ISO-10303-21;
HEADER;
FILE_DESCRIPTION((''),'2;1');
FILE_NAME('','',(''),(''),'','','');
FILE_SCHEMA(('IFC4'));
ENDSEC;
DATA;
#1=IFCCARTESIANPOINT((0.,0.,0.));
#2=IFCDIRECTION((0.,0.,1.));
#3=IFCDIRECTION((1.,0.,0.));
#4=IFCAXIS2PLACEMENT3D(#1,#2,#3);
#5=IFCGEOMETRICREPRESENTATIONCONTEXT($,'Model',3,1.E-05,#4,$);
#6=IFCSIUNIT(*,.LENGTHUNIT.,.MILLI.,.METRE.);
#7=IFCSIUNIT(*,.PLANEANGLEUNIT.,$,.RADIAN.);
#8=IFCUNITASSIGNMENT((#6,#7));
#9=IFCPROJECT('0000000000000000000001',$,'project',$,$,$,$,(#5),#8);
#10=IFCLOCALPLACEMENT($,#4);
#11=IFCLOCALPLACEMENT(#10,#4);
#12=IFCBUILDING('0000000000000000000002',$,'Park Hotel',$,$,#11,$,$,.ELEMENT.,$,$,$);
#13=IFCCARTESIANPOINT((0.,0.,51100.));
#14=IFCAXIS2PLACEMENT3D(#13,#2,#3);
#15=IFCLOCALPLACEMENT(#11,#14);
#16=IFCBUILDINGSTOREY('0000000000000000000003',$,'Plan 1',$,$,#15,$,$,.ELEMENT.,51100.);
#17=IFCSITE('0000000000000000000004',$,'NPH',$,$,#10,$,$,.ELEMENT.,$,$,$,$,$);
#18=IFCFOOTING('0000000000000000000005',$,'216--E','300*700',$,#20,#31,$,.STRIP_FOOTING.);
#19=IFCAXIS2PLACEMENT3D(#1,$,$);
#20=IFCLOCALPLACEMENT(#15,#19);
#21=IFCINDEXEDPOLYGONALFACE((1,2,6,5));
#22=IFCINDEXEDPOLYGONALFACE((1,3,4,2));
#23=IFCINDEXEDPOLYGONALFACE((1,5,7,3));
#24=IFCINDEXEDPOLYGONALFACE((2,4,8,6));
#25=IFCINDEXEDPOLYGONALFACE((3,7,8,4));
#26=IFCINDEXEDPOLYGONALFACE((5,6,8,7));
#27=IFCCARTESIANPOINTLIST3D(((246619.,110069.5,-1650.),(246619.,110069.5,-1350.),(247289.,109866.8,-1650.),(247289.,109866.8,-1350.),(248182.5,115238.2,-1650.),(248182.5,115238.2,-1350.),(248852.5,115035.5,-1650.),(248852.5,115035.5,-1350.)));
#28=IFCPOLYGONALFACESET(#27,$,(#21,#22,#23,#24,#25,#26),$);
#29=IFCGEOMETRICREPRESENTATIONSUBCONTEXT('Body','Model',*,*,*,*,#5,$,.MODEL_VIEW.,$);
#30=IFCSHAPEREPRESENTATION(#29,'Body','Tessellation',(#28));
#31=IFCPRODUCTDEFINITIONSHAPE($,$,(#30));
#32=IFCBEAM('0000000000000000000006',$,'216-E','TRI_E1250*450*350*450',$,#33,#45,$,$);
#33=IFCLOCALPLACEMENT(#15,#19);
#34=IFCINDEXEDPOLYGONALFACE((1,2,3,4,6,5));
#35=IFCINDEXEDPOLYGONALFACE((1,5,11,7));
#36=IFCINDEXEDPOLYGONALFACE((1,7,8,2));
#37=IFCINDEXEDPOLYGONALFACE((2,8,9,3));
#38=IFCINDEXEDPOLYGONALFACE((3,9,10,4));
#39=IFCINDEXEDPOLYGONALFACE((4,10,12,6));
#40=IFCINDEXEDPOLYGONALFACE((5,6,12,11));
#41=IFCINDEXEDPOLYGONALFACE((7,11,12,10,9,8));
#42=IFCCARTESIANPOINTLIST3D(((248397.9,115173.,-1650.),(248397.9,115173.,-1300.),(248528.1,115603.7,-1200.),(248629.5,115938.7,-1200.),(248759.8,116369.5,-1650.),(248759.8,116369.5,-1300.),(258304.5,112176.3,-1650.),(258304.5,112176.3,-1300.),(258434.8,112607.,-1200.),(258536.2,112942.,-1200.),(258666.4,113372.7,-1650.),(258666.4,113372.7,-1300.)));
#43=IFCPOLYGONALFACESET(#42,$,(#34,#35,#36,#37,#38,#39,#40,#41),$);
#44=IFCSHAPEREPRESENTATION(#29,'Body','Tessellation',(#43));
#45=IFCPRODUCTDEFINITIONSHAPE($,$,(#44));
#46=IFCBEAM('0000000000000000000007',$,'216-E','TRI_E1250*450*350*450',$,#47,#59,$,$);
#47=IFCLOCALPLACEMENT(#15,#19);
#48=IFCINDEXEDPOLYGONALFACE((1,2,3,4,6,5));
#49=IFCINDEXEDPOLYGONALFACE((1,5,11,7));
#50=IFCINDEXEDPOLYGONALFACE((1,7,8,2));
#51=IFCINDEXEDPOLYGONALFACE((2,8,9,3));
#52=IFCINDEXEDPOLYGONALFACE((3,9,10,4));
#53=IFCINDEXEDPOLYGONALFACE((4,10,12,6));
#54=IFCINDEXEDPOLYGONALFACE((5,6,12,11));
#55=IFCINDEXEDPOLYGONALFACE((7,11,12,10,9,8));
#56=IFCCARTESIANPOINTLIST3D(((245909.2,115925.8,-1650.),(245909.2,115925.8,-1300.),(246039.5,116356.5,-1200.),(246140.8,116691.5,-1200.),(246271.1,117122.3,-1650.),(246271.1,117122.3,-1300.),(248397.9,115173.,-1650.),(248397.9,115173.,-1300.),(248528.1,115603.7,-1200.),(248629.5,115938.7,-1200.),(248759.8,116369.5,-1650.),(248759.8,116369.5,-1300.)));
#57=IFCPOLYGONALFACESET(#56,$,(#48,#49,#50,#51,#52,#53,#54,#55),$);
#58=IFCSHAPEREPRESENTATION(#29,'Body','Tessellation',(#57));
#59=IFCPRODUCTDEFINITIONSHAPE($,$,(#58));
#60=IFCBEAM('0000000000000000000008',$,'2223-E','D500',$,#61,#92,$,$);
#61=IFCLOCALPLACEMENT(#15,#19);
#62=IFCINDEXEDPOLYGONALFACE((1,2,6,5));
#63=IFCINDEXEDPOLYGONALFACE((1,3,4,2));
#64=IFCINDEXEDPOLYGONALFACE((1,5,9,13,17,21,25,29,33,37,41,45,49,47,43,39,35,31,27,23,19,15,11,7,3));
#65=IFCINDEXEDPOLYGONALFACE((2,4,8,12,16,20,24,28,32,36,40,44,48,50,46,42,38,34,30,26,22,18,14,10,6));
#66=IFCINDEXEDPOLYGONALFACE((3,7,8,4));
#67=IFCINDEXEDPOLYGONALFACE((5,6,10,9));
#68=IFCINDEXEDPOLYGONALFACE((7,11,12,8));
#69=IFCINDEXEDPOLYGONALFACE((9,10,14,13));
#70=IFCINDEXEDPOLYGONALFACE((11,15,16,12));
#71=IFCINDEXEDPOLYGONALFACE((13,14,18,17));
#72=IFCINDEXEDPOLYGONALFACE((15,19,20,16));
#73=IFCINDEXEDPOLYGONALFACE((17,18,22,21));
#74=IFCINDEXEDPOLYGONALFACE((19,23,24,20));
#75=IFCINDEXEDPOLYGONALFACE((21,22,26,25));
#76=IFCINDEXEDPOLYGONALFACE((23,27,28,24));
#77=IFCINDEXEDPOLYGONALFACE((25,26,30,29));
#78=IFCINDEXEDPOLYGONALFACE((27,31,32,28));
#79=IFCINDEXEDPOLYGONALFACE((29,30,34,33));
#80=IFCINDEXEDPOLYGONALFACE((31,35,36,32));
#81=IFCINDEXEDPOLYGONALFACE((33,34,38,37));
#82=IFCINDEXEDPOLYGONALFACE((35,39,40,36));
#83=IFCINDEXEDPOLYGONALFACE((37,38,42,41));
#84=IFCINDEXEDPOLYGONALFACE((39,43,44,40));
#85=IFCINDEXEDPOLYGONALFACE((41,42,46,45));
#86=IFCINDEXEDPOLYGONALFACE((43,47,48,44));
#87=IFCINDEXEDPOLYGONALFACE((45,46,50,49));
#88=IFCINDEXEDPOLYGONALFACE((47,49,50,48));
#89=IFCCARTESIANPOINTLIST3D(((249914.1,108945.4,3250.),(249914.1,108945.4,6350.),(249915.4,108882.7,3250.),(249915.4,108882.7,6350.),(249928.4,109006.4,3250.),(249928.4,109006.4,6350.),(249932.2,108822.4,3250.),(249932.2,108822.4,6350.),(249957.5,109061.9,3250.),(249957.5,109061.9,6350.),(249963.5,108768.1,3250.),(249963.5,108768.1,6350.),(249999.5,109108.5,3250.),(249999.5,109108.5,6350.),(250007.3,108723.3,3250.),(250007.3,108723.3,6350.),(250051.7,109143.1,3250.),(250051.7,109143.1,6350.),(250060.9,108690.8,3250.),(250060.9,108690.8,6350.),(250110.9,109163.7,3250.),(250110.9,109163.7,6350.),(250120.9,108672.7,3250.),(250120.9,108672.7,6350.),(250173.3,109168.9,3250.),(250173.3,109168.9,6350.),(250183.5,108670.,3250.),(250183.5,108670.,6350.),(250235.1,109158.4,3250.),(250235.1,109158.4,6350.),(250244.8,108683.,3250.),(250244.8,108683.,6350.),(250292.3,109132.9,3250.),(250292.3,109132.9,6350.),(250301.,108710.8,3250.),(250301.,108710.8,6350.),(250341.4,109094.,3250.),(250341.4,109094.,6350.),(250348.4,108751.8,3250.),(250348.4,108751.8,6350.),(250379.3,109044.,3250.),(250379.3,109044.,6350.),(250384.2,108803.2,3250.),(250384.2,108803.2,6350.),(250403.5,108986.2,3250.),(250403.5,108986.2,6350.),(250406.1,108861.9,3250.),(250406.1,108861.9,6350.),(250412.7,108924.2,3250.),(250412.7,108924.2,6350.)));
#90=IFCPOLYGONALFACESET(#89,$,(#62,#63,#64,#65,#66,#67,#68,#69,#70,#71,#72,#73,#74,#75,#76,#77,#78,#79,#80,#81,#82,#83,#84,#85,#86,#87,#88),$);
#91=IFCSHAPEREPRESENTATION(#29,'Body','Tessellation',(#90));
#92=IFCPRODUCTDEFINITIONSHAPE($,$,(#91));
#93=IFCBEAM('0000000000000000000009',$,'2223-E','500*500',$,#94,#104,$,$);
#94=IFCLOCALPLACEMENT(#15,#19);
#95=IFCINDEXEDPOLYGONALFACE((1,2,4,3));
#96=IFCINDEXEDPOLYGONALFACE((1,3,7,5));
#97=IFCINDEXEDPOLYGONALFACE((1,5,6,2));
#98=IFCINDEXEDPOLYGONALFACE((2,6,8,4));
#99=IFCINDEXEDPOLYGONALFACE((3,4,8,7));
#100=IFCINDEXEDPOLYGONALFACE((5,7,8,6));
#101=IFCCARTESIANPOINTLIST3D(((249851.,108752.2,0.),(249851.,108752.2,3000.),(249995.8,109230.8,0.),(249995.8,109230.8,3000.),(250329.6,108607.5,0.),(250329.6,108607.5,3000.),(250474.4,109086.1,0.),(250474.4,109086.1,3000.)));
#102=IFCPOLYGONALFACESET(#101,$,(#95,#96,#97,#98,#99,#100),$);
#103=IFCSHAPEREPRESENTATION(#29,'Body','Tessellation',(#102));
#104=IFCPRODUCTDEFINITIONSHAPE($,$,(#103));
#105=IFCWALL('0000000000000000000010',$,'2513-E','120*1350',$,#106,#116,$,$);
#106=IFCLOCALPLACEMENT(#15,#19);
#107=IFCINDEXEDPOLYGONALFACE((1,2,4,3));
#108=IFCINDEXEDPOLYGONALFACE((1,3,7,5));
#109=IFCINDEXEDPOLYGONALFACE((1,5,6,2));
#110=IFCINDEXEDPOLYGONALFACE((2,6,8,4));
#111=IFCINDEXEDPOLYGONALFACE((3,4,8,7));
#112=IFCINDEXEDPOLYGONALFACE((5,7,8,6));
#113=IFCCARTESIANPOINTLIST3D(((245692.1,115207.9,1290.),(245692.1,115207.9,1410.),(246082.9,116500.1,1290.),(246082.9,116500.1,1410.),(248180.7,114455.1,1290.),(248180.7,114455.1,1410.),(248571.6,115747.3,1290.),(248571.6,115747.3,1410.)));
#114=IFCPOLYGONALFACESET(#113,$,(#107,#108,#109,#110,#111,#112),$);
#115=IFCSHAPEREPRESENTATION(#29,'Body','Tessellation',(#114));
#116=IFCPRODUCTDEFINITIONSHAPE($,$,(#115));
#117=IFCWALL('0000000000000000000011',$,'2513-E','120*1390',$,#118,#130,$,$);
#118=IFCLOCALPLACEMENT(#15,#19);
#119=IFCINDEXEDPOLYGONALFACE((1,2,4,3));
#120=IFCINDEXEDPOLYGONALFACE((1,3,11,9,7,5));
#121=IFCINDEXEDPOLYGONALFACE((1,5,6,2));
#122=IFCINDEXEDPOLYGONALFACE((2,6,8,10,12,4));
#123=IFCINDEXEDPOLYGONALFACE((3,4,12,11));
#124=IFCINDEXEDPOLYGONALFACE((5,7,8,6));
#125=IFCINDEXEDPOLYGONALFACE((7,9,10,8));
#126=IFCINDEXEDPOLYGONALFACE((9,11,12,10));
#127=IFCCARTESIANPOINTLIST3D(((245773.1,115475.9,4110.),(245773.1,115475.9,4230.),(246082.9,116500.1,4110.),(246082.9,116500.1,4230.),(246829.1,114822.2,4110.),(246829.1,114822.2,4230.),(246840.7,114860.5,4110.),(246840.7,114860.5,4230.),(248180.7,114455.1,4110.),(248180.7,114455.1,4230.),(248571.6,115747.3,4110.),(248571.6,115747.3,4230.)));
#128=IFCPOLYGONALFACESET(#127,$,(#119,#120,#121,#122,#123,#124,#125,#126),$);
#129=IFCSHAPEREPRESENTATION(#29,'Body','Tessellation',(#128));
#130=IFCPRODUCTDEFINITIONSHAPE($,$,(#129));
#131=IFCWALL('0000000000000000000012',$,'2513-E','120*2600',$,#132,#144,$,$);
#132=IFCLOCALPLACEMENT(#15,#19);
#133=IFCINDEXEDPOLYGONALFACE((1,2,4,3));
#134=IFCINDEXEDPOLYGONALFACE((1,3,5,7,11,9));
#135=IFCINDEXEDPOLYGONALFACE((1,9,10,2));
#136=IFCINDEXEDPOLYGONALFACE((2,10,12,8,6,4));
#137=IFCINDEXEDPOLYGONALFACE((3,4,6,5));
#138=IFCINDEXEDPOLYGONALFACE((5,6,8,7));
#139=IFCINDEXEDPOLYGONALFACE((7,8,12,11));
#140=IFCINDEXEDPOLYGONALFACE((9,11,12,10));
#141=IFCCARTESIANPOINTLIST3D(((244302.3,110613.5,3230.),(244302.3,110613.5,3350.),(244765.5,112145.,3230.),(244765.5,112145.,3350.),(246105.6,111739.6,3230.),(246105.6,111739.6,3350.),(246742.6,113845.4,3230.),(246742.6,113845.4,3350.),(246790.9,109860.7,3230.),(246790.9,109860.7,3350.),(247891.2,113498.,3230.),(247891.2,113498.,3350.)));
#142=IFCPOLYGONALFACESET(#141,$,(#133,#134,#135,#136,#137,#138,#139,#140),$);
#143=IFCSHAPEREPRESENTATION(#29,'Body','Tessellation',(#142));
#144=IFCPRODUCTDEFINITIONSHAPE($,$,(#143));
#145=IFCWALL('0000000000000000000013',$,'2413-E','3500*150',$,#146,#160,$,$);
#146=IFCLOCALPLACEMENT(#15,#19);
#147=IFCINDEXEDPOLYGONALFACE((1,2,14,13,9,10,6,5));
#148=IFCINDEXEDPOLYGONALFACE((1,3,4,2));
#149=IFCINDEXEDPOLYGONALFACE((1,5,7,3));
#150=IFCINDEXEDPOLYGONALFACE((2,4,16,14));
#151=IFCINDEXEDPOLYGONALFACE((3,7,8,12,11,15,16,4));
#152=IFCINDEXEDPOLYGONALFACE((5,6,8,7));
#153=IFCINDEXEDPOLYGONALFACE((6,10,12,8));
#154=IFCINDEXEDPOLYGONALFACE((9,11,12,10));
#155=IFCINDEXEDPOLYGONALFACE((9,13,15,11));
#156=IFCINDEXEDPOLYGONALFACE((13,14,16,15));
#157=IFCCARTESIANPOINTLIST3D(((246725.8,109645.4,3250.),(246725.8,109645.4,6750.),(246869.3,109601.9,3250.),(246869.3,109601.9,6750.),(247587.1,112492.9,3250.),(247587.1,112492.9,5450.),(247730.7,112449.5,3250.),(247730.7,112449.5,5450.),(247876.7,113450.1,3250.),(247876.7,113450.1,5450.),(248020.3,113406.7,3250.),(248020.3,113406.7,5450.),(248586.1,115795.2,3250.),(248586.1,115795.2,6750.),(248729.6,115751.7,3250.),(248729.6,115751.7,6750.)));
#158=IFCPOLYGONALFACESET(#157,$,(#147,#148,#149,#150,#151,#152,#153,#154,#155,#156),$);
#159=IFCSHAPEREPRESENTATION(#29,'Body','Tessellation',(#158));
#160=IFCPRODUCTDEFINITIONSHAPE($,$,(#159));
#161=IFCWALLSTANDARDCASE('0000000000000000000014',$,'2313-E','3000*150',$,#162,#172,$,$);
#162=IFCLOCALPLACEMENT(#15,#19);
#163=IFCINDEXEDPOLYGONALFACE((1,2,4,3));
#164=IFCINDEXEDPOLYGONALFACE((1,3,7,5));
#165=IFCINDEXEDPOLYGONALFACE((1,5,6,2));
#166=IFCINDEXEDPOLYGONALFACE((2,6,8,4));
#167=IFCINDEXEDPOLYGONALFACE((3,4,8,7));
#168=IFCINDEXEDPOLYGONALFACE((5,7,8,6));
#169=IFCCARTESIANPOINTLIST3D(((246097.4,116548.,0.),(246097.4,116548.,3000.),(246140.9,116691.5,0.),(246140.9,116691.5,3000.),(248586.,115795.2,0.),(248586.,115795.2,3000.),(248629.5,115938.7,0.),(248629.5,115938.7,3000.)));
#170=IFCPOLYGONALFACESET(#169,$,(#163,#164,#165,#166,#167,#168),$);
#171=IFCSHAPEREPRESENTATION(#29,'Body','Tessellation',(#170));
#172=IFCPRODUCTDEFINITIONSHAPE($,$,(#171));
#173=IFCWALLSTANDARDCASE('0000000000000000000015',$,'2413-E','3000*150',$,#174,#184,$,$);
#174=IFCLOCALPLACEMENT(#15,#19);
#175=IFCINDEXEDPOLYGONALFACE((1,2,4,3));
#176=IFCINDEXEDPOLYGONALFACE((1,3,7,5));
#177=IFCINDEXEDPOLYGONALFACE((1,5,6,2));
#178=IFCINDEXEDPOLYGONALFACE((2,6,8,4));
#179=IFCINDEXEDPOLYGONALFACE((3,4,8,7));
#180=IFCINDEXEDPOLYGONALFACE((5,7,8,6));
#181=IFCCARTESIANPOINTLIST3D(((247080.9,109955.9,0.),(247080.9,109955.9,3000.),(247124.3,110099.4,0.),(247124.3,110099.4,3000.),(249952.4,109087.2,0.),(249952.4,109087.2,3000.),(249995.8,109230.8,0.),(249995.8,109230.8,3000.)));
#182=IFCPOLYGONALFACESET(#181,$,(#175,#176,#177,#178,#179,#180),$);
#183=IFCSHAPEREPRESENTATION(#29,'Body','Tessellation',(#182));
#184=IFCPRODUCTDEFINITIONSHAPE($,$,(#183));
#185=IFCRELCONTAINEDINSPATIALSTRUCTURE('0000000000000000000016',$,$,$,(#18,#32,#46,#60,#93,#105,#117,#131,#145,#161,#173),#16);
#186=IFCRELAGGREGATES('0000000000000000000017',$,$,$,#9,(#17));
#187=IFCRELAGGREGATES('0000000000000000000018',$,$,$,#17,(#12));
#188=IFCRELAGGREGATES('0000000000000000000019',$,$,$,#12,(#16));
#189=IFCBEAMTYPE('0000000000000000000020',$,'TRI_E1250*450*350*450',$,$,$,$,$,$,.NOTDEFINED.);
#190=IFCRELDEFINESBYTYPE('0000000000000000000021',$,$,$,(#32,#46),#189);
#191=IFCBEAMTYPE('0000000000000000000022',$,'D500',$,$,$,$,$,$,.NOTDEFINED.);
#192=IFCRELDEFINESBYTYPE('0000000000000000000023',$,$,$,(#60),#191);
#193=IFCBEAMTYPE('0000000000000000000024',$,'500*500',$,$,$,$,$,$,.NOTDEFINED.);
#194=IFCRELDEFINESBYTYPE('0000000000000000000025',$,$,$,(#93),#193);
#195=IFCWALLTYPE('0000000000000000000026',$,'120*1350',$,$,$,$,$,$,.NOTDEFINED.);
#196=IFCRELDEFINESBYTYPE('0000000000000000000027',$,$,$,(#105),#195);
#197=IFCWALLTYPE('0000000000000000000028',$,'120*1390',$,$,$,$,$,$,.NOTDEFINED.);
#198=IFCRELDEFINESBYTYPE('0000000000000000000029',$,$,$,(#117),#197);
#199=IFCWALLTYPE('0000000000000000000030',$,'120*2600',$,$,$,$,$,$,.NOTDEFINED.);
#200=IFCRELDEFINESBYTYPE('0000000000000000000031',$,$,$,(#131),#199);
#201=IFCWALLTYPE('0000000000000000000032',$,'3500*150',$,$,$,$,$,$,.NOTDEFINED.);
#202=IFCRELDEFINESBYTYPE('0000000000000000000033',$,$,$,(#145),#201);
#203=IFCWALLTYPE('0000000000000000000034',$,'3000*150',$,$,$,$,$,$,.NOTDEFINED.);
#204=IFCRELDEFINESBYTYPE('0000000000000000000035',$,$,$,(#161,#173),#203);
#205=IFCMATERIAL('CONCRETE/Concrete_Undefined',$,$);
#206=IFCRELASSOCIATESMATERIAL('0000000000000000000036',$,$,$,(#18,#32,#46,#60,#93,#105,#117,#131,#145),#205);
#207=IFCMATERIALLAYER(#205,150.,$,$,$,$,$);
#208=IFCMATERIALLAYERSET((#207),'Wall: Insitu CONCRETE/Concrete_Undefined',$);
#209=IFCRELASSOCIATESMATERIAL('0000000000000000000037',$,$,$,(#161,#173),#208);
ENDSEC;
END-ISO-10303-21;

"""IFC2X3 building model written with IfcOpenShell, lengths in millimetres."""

from ifc_helpers import new_model, si_unit, frame, frame_2d, origin_with_axes, origin_2d_with_axis, place, context, subcontext, project, spatial, polyline, rectangle, circle, outline, extrude, boolean, material, layer, layer_set, layer_usage, type_object, element, save


model = new_model("IFC2X3")

# Units and contexts
model_context = context("Model", 3, precision=1e-05, world=origin_with_axes())
body_context = subcontext(model_context, "Body", "Model", "MODEL_VIEW")
ifc_project = project(units=[si_unit("LENGTHUNIT", "METRE", prefix="MILLI"), si_unit("PLANEANGLEUNIT", "RADIAN")], contexts=[model_context])

# Site, building, storey
site_placement = place(None, origin_with_axes())
site = spatial("IfcSite", under=ifc_project, at=site_placement, Name="NPH", CompositionType="ELEMENT")
building_placement = place(site_placement, origin_with_axes())
building = spatial("IfcBuilding", under=site, at=building_placement, Name="Park Hotel", CompositionType="ELEMENT")
storey_placement = place(building_placement, frame((0.0, 0.0, 51100.0), z_axis=(0.0, 0.0, 1.0), x_axis=(1.0, 0.0, 0.0)))
storey = spatial("IfcBuildingStorey", under=building, at=storey_placement, Name="Plan 1", CompositionType="ELEMENT", Elevation=51100.0)

# Footing
ifc_material_1 = material(Name="CONCRETE/Concrete_Undefined")
footing_placement = place(storey_placement, frame((246954.0, 109968.1, -1500.0), z_axis=(0.0, 0.0, 1.0), x_axis=(0.289538, 0.957167, 0.0)))
element("IfcFooting", 1, at=footing_placement, inside=storey, material=ifc_material_1, Name="216--E", Description="300*700", PredefinedType="STRIP_FOOTING", context=body_context, shape_type="SweptSolid", body=[
    extrude(rectangle(XDim=700.0, YDim=300.0, at=origin_2d_with_axis()), frame((5400.0, 0.0, 0.0), z_axis=(-1.0, 0.0, 0.0), x_axis=(0.0, -1.0, 0.0)), (0.0, 0.0, 1.0), 5400.0),
])

# Beams
beam_type_1 = type_object("IfcBeamType", Name="TRI_E1250*450*350*450", PredefinedType="NOTDEFINED")
beam_1_placement = place(storey_placement, frame((248578.8, 115771.2, -1425.0), z_axis=(0.0, 0.0, 1.0), x_axis=(0.957167, -0.289538, 0.0)))
element("IfcBeam", 2, at=beam_1_placement, inside=storey, type_object=beam_type_1, material=ifc_material_1, Name="216-E", Description="TRI_E1250*450*350*450", context=body_context, shape_type="SweptSolid", body=[
    extrude(outline(polyline([(625.0, -225.0), (-625.0, -225.0), (-625.0, 125.0), (-175.0, 225.0), (175.0, 225.0), (625.0, 125.0), (625.0, -225.0)])), frame((10350.0, 0.0, 0.0), z_axis=(-1.0, 0.0, 0.0), x_axis=(0.0, -1.0, 0.0)), (0.0, 0.0, 1.0), 10350.0),
])
beam_2_placement = place(storey_placement, frame((246090.2, 116524.0, -1425.0), z_axis=(0.0, 0.0, 1.0), x_axis=(0.957167, -0.289538, 0.0)))
element("IfcBeam", 3, at=beam_2_placement, inside=storey, type_object=beam_type_1, material=ifc_material_1, Name="216-E", Description="TRI_E1250*450*350*450", context=body_context, shape_type="SweptSolid", body=[
    extrude(outline(polyline([(625.0, -225.0), (-625.0, -225.0), (-625.0, 125.0), (-175.0, 225.0), (175.0, 225.0), (625.0, 125.0), (625.0, -225.0)])), frame((2600.0, 0.0, 0.0), z_axis=(-1.0, 0.0, 0.0), x_axis=(0.0, -1.0, 0.0)), (0.0, 0.0, 1.0), 2600.0),
])
beam_type_2 = type_object("IfcBeamType", Name="D500", PredefinedType="NOTDEFINED")
beam_3_placement = place(storey_placement, frame((250162.7, 108919.1, 3250.0), z_axis=(0.957167, -0.289538, 0.0), x_axis=(0.0, 0.0, 1.0)))
element("IfcBeam", 4, at=beam_3_placement, inside=storey, type_object=beam_type_2, material=ifc_material_1, Name="2223-E", Description="D500", context=body_context, shape_type="SweptSolid", body=[
    extrude(circle(Radius=250.0, at=origin_2d_with_axis()), frame((3100.0, 0.0, 0.0), z_axis=(-1.0, 0.0, 0.0), x_axis=(0.0, -1.0, 0.0)), (0.0, 0.0, 1.0), 3100.0),
])
beam_type_3 = type_object("IfcBeamType", Name="500*500", PredefinedType="NOTDEFINED")
beam_4_placement = place(storey_placement, frame((250162.7, 108919.1, 0.0), z_axis=(0.957167, -0.289538, 0.0), x_axis=(0.0, 0.0, 1.0)))
element("IfcBeam", 5, at=beam_4_placement, inside=storey, type_object=beam_type_3, material=ifc_material_1, Name="2223-E", Description="500*500", context=body_context, shape_type="SweptSolid", body=[
    extrude(rectangle(XDim=500.0, YDim=500.0, at=origin_2d_with_axis()), frame((3000.0, 0.0, 0.0), z_axis=(-1.0, 0.0, 0.0), x_axis=(0.0, -1.0, 0.0)), (0.0, 0.0, 1.0), 3000.0),
])

# Walls
wall_type_1 = type_object("IfcWallType", Name="120*1350", PredefinedType="NOTDEFINED")
wall_1_placement = place(storey_placement, frame((248180.7, 114455.1, 1350.0), z_axis=(0.0, 0.0, 1.0), x_axis=(0.289538, 0.957167, 0.0)))
element("IfcWall", 6, at=wall_1_placement, inside=storey, type_object=wall_type_1, material=ifc_material_1, Name="2513-E", Description="120*1350", context=body_context, shape_type="SweptSolid", body=[
    extrude(outline(polyline([(0.0, 0.0), (1350.0, 0.0), (1350.0, 2600.0), (0.0, 2600.0), (0.0, 0.0)])), frame((0.0, 0.0, -60.0), z_axis=(0.0, 0.0, 1.0), x_axis=(1.0, 0.0, 0.0)), (0.0, 0.0, 1.0), 120.0),
])
wall_type_2 = type_object("IfcWallType", Name="120*1390", PredefinedType="NOTDEFINED")
wall_2_placement = place(storey_placement, frame((248180.7, 114455.1, 4170.0), z_axis=(0.0, 0.0, 1.0), x_axis=(0.289538, 0.957167, 0.0)))
element("IfcWall", 7, at=wall_2_placement, inside=storey, type_object=wall_type_2, material=ifc_material_1, Name="2513-E", Description="120*1390", context=body_context, shape_type="SweptSolid", body=[
    extrude(outline(polyline([(0.0, 0.0), (1350.0, 0.0), (1350.0, 2600.0), (280.0, 2600.0), (-40.0, 1400.0), (0.0, 1400.0), (0.0, 0.0)])), frame((0.0, 0.0, -60.0), z_axis=(0.0, 0.0, 1.0), x_axis=(1.0, 0.0, 0.0)), (0.0, 0.0, 1.0), 120.0),
])
wall_type_3 = type_object("IfcWallType", Name="120*2600", PredefinedType="NOTDEFINED")
wall_3_placement = place(storey_placement, frame((246790.9, 109860.7, 3290.0), z_axis=(0.0, 0.0, 1.0), x_axis=(0.289538, 0.957167, 0.0)))
element("IfcWall", 8, at=wall_3_placement, inside=storey, type_object=wall_type_3, material=ifc_material_1, Name="2513-E", Description="120*2600", context=body_context, shape_type="SweptSolid", body=[
    extrude(outline(polyline([(0.0, 0.0), (3800.0, 0.0), (3800.0, 1200.0), (1600.0, 1200.0), (1600.0, 2600.0), (0.0, 2600.0), (0.0, 0.0)])), frame((0.0, 0.0, -60.0), z_axis=(0.0, 0.0, 1.0), x_axis=(1.0, 0.0, 0.0)), (0.0, 0.0, 1.0), 120.0),
])
wall_type_4 = type_object("IfcWallType", Name="3500*150", PredefinedType="NOTDEFINED")
wall_4_placement = place(storey_placement, frame((246797.6, 109623.7, 3250.0), z_axis=(0.0, 0.0, 1.0), x_axis=(0.289538, 0.957167, 0.0)))
element("IfcWall", 9, at=wall_4_placement, inside=storey, type_object=wall_type_4, material=ifc_material_1, Name="2413-E", Description="3500*150", context=body_context, shape_type="CSG", body=[
    boolean("DIFFERENCE", extrude(rectangle(XDim=6425.0, YDim=150.0, at=frame_2d((0.0, 3212.5), x_axis=(0.0, -1.0))), frame((0.0, 0.0, 0.0), z_axis=(0.0, 0.0, 1.0), x_axis=(0.0, -1.0, 0.0)), (0.0, 0.0, 1.0), 3500.0), extrude(rectangle(XDim=1000.0, YDim=200.0, at=frame_2d((0.0, 500.0), x_axis=(0.0, -1.0))), frame((3975.0, -25.0, 0.0), z_axis=(0.0, 0.0, 1.0), x_axis=(0.000005, 1.0, 0.0)), (0.0, 0.0, 1.0), 2200.0)),
])
ifc_layer_1 = layer(ifc_material_1, 150.0)
ifc_layer_set_1 = layer_set([ifc_layer_1], Name="Wall: Insitu CONCRETE/Concrete_Undefined")
ifc_layer_usage_1 = layer_usage(ifc_layer_set_1, "AXIS2", "POSITIVE", -75.0)
wall_type_5 = type_object("IfcWallType", Name="3000*150", PredefinedType="NOTDEFINED")
wall_5_placement = place(storey_placement, frame((246119.1, 116619.8, 0.0), z_axis=(0.0, 0.0, 1.0), x_axis=(0.957166, -0.289541, 0.0)))
element("IfcWallStandardCase", 10, at=wall_5_placement, inside=storey, type_object=wall_type_5, material=ifc_layer_usage_1, Name="2313-E", Description="3000*150", context=body_context, shape_type="SweptSolid", body=[
    extrude(rectangle(XDim=2600.0, YDim=150.0, at=frame_2d((0.0, 1300.0), x_axis=(0.0, -1.0))), frame((0.0, 0.0, 0.0), z_axis=(0.0, 0.0, 1.0), x_axis=(0.0, -1.0, 0.0)), (0.0, 0.0, 1.0), 3000.0),
])
ifc_layer_usage_2 = layer_usage(ifc_layer_set_1, "AXIS2", "POSITIVE", -75.0)
wall_6_placement = place(storey_placement, frame((247102.6, 110027.6, 0.0), z_axis=(0.0, 0.0, 1.0), x_axis=(0.957167, -0.289536, 0.0)))
element("IfcWallStandardCase", 11, at=wall_6_placement, inside=storey, type_object=wall_type_5, material=ifc_layer_usage_2, Name="2413-E", Description="3000*150", context=body_context, shape_type="SweptSolid", body=[
    extrude(rectangle(XDim=3000.0, YDim=150.0, at=frame_2d((0.0, 1500.0), x_axis=(0.0, -1.0))), frame((0.0, 0.0, 0.0), z_axis=(0.0, 0.0, 1.0), x_axis=(0.0, -1.0, 0.0)), (0.0, 0.0, 1.0), 3000.0),
])

save(model, "model.ifc")
